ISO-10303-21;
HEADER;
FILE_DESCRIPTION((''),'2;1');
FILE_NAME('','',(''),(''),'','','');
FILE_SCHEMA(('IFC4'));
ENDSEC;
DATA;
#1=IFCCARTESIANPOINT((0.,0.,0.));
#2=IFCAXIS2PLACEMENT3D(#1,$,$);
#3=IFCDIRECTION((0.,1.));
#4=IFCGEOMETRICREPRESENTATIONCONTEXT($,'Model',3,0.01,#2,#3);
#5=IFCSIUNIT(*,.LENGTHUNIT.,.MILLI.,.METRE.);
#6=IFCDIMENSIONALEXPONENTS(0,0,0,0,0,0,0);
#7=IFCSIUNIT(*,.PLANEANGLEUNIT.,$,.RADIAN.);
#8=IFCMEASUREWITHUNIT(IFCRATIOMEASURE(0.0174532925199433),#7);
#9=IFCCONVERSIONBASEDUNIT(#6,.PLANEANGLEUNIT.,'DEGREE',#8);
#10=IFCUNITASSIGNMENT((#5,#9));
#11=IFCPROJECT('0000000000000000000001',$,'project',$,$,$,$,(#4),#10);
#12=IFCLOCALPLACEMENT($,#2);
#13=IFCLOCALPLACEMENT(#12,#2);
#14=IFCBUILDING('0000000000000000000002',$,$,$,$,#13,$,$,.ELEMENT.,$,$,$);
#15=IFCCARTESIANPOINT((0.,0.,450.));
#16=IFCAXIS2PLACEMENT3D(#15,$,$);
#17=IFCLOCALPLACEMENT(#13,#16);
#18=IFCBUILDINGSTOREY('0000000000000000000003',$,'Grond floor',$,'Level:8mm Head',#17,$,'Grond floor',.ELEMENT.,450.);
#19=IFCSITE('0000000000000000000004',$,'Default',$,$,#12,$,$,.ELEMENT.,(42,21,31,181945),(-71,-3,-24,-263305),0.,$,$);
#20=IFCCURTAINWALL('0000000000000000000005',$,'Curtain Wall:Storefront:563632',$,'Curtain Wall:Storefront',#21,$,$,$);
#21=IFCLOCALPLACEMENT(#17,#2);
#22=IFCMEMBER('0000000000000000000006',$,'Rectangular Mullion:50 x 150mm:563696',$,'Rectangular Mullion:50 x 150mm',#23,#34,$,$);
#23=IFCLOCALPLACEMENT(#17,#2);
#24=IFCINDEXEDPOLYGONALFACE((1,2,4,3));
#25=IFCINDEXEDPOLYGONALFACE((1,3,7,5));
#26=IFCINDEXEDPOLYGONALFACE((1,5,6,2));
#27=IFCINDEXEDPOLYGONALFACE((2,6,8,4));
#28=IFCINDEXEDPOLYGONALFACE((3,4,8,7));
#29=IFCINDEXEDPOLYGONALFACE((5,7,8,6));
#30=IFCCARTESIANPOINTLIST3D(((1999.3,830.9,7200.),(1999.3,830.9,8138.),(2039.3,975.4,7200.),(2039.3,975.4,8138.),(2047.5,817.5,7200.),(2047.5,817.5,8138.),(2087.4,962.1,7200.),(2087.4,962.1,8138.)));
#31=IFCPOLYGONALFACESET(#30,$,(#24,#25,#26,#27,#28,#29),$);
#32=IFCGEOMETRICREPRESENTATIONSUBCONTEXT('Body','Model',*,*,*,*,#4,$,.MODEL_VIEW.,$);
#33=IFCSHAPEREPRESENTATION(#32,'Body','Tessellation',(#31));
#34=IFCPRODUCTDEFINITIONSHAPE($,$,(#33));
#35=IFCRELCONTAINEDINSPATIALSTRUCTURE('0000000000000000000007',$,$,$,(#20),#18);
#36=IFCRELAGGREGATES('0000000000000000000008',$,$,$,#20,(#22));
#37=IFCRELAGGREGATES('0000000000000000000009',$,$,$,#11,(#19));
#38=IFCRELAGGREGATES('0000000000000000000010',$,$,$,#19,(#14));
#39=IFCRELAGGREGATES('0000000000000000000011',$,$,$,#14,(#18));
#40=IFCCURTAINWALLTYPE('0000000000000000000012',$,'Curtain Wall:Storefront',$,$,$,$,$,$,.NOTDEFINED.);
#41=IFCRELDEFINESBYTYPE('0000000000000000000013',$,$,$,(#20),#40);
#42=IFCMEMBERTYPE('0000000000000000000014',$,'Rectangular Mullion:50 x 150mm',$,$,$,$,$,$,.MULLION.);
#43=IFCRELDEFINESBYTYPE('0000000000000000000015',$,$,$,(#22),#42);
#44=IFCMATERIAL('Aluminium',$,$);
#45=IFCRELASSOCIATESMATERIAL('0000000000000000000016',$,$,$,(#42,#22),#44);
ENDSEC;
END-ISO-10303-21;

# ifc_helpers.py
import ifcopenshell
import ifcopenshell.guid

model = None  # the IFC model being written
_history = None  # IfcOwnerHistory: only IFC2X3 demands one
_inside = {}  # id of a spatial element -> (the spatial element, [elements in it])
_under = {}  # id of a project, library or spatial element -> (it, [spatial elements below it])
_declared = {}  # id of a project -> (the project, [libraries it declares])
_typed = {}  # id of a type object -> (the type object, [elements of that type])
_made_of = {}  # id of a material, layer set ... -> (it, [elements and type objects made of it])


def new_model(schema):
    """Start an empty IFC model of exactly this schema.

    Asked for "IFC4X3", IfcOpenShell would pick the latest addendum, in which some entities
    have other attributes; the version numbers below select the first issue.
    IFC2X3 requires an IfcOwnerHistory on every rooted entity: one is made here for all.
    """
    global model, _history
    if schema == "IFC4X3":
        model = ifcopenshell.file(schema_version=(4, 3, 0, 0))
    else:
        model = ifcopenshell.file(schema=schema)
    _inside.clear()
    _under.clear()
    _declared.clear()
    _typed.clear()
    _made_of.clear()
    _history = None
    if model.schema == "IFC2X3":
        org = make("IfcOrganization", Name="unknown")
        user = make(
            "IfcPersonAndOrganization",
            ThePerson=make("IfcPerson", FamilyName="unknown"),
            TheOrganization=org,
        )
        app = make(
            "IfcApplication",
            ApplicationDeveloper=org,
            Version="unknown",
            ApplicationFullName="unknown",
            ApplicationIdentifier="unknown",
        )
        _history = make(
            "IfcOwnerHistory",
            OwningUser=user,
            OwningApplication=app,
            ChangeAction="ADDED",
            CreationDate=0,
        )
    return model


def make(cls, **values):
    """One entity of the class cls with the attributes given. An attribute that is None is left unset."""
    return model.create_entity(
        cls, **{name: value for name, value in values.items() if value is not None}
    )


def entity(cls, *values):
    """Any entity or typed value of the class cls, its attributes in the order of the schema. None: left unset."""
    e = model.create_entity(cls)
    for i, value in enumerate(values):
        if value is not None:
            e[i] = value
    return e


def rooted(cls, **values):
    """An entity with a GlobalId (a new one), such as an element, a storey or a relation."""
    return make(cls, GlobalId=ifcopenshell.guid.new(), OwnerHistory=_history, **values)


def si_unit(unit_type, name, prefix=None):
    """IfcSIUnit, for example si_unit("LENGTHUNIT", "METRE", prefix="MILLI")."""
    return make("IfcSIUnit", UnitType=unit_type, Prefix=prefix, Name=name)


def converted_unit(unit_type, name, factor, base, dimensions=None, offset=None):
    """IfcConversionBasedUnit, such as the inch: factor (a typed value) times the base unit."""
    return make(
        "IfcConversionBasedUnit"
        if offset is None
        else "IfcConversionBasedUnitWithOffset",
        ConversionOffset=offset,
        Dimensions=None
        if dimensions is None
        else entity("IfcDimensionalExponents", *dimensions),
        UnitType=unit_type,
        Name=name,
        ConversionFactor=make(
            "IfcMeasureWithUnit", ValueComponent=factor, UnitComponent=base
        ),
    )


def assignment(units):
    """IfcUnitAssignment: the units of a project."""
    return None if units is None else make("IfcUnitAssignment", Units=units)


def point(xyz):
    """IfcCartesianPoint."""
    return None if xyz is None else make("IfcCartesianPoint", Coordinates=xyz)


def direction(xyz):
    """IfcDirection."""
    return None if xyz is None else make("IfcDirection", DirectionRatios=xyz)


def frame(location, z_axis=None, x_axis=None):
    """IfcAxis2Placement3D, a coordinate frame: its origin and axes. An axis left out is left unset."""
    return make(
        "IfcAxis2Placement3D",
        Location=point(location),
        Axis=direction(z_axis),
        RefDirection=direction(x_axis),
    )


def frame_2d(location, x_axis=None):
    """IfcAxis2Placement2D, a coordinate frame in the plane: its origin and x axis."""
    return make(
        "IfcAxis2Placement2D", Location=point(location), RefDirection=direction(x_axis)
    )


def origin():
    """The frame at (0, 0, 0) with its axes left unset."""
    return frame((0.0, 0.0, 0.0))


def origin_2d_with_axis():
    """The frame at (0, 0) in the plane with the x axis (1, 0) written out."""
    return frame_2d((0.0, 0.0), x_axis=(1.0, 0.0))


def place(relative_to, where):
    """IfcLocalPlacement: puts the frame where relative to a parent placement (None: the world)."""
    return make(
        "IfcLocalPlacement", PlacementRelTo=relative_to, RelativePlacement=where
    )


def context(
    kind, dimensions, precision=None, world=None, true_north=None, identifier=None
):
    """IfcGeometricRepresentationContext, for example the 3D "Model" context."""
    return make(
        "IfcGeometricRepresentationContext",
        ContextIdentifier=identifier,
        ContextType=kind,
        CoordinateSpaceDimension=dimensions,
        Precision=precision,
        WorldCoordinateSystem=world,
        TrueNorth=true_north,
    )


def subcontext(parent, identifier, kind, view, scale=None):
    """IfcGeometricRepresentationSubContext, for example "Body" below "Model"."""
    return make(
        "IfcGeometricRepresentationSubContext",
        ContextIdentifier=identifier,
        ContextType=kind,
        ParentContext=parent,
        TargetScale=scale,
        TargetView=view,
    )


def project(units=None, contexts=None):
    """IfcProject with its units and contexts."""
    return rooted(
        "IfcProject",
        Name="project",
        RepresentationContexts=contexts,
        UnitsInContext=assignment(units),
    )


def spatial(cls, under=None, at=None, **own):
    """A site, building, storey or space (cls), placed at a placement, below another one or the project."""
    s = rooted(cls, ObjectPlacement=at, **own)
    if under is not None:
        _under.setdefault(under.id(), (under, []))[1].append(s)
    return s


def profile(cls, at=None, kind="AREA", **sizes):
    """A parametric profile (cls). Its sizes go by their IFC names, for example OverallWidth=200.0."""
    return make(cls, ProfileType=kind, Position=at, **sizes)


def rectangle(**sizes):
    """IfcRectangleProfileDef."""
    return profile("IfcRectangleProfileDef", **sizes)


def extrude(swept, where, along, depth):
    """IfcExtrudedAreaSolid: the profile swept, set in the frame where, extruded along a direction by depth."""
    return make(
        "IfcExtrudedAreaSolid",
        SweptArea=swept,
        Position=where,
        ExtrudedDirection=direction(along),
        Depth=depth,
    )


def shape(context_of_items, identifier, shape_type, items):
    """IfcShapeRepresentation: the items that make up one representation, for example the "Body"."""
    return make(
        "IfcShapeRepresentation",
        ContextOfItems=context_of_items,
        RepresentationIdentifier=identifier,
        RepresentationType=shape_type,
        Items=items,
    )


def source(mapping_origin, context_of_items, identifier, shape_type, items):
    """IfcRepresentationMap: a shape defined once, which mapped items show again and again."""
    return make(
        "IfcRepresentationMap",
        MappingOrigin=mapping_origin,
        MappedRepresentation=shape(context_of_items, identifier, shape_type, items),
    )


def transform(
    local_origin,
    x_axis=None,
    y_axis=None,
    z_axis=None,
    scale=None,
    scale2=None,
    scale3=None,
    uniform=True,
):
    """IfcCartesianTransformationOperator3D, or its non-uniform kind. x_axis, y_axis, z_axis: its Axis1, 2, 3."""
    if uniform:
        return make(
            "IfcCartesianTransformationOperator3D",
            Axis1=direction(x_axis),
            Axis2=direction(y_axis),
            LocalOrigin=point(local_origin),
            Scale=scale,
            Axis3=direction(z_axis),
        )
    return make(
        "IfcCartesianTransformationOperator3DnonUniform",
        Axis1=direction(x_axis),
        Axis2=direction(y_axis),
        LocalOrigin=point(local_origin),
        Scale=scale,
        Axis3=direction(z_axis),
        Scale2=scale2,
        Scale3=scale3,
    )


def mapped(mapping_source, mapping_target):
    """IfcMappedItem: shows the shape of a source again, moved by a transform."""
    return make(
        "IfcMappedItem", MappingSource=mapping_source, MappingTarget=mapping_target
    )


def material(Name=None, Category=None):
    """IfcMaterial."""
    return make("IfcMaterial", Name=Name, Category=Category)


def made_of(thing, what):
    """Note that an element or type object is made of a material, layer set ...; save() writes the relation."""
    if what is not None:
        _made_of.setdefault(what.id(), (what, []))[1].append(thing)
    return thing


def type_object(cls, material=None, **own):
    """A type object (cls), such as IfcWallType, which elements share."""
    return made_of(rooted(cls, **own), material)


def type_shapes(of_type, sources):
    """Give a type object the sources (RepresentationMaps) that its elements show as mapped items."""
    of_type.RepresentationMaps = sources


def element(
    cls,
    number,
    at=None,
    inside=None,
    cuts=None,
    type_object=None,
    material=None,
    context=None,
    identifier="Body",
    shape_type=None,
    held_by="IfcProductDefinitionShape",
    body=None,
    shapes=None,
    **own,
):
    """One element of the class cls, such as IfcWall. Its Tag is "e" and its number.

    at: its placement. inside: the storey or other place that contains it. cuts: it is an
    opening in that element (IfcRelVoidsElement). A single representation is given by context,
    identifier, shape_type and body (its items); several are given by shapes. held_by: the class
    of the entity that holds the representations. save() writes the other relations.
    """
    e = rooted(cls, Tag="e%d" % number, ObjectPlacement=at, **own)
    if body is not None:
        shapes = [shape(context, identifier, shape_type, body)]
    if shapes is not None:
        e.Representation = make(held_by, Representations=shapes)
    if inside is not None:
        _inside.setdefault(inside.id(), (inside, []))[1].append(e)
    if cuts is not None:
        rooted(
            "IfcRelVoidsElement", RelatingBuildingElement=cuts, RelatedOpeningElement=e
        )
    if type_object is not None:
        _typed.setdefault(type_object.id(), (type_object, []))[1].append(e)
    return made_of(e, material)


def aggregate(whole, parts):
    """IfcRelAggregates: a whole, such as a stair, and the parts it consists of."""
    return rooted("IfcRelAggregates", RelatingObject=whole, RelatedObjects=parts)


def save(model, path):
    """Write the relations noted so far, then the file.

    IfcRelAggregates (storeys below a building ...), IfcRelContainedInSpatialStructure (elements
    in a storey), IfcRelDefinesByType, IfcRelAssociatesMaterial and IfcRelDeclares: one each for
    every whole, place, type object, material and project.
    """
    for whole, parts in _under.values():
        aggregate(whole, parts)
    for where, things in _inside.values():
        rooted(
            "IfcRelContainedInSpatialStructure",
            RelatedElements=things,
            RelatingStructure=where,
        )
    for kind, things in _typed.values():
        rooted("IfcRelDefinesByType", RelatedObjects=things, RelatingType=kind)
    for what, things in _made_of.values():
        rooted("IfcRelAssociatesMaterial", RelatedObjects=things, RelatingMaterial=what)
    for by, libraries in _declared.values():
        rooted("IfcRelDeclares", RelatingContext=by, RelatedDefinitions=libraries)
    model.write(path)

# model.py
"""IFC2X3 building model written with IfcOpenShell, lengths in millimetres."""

from ifc_helpers import new_model, entity, si_unit, converted_unit, direction, frame, origin, origin_2d_with_axis, place, context, subcontext, project, spatial, rectangle, extrude, source, transform, mapped, material, type_object, type_shapes, element, aggregate, save


model = new_model("IFC2X3")

# Units and contexts
model_context = context("Model", 3, precision=0.01, world=origin(), true_north=direction((0.0, 1.0)))
body_context = subcontext(model_context, "Body", "Model", "MODEL_VIEW")
ifc_project = project(units=[si_unit("LENGTHUNIT", "METRE", prefix="MILLI"), converted_unit("PLANEANGLEUNIT", "DEGREE", entity("IfcRatioMeasure", 0.0174532925199433), si_unit("PLANEANGLEUNIT", "RADIAN"), dimensions=[0, 0, 0, 0, 0, 0, 0])], contexts=[model_context])

# Site, building, storey
site_placement = place(None, origin())
site = spatial("IfcSite", under=ifc_project, at=site_placement, Name="Default", CompositionType="ELEMENT", RefLatitude=(42, 21, 31, 181945), RefLongitude=(-71, -3, -24, -263305), RefElevation=0.0)
building_placement = place(site_placement, origin())
building = spatial("IfcBuilding", under=site, at=building_placement, CompositionType="ELEMENT")
storey_placement = place(building_placement, frame((0.0, 0.0, 450.0)))
storey = spatial("IfcBuildingStorey", under=building, at=storey_placement, Name="Grond floor", ObjectType="Level:8mm Head", LongName="Grond floor", CompositionType="ELEMENT", Elevation=450.0)

# Curtain wall, member
curtain_wall_type = type_object("IfcCurtainWallType", Name="Curtain Wall:Storefront", PredefinedType="NOTDEFINED")
curtain_wall_placement = place(storey_placement, frame((0.0, 0.0, -450.0)))
curtain_wall = element("IfcCurtainWall", 1, at=curtain_wall_placement, inside=storey, type_object=curtain_wall_type, Name="Curtain Wall:Storefront:563632", ObjectType="Curtain Wall:Storefront")
ifc_material_1 = material(Name="Aluminium")
member_type_1 = type_object("IfcMemberType", Name="Rectangular Mullion:50 x 150mm", PredefinedType="MULLION", material=ifc_material_1)
shared_shape_1 = source(origin(), body_context, "Body", "SweptSolid", [
    extrude(rectangle(XDim=150.0, YDim=50.0, at=origin_2d_with_axis()), frame((0.0, 0.0, -938.0), z_axis=(0.0, 0.0, 1.0), x_axis=(0.0, -1.0, 0.0)), (0.0, 0.0, 1.0), 938.0),
])
type_shapes(member_type_1, [shared_shape_1])
member_1_placement = place(storey_placement, frame((2043.4, 896.5, 7200.0), z_axis=(0.0, 0.0, -1.0), x_axis=(-0.963836, 0.266496, 0.0)))
member_1 = element("IfcMember", 2, at=member_1_placement, type_object=member_type_1, material=ifc_material_1, Name="Rectangular Mullion:50 x 150mm:563696", ObjectType="Rectangular Mullion:50 x 150mm", context=body_context, shape_type="MappedRepresentation", body=[
    mapped(shared_shape_1, transform((0.0, 0.0, 0.0), scale=1.0)),
])
aggregate(curtain_wall, [member_1])

save(model, "model.ifc")
